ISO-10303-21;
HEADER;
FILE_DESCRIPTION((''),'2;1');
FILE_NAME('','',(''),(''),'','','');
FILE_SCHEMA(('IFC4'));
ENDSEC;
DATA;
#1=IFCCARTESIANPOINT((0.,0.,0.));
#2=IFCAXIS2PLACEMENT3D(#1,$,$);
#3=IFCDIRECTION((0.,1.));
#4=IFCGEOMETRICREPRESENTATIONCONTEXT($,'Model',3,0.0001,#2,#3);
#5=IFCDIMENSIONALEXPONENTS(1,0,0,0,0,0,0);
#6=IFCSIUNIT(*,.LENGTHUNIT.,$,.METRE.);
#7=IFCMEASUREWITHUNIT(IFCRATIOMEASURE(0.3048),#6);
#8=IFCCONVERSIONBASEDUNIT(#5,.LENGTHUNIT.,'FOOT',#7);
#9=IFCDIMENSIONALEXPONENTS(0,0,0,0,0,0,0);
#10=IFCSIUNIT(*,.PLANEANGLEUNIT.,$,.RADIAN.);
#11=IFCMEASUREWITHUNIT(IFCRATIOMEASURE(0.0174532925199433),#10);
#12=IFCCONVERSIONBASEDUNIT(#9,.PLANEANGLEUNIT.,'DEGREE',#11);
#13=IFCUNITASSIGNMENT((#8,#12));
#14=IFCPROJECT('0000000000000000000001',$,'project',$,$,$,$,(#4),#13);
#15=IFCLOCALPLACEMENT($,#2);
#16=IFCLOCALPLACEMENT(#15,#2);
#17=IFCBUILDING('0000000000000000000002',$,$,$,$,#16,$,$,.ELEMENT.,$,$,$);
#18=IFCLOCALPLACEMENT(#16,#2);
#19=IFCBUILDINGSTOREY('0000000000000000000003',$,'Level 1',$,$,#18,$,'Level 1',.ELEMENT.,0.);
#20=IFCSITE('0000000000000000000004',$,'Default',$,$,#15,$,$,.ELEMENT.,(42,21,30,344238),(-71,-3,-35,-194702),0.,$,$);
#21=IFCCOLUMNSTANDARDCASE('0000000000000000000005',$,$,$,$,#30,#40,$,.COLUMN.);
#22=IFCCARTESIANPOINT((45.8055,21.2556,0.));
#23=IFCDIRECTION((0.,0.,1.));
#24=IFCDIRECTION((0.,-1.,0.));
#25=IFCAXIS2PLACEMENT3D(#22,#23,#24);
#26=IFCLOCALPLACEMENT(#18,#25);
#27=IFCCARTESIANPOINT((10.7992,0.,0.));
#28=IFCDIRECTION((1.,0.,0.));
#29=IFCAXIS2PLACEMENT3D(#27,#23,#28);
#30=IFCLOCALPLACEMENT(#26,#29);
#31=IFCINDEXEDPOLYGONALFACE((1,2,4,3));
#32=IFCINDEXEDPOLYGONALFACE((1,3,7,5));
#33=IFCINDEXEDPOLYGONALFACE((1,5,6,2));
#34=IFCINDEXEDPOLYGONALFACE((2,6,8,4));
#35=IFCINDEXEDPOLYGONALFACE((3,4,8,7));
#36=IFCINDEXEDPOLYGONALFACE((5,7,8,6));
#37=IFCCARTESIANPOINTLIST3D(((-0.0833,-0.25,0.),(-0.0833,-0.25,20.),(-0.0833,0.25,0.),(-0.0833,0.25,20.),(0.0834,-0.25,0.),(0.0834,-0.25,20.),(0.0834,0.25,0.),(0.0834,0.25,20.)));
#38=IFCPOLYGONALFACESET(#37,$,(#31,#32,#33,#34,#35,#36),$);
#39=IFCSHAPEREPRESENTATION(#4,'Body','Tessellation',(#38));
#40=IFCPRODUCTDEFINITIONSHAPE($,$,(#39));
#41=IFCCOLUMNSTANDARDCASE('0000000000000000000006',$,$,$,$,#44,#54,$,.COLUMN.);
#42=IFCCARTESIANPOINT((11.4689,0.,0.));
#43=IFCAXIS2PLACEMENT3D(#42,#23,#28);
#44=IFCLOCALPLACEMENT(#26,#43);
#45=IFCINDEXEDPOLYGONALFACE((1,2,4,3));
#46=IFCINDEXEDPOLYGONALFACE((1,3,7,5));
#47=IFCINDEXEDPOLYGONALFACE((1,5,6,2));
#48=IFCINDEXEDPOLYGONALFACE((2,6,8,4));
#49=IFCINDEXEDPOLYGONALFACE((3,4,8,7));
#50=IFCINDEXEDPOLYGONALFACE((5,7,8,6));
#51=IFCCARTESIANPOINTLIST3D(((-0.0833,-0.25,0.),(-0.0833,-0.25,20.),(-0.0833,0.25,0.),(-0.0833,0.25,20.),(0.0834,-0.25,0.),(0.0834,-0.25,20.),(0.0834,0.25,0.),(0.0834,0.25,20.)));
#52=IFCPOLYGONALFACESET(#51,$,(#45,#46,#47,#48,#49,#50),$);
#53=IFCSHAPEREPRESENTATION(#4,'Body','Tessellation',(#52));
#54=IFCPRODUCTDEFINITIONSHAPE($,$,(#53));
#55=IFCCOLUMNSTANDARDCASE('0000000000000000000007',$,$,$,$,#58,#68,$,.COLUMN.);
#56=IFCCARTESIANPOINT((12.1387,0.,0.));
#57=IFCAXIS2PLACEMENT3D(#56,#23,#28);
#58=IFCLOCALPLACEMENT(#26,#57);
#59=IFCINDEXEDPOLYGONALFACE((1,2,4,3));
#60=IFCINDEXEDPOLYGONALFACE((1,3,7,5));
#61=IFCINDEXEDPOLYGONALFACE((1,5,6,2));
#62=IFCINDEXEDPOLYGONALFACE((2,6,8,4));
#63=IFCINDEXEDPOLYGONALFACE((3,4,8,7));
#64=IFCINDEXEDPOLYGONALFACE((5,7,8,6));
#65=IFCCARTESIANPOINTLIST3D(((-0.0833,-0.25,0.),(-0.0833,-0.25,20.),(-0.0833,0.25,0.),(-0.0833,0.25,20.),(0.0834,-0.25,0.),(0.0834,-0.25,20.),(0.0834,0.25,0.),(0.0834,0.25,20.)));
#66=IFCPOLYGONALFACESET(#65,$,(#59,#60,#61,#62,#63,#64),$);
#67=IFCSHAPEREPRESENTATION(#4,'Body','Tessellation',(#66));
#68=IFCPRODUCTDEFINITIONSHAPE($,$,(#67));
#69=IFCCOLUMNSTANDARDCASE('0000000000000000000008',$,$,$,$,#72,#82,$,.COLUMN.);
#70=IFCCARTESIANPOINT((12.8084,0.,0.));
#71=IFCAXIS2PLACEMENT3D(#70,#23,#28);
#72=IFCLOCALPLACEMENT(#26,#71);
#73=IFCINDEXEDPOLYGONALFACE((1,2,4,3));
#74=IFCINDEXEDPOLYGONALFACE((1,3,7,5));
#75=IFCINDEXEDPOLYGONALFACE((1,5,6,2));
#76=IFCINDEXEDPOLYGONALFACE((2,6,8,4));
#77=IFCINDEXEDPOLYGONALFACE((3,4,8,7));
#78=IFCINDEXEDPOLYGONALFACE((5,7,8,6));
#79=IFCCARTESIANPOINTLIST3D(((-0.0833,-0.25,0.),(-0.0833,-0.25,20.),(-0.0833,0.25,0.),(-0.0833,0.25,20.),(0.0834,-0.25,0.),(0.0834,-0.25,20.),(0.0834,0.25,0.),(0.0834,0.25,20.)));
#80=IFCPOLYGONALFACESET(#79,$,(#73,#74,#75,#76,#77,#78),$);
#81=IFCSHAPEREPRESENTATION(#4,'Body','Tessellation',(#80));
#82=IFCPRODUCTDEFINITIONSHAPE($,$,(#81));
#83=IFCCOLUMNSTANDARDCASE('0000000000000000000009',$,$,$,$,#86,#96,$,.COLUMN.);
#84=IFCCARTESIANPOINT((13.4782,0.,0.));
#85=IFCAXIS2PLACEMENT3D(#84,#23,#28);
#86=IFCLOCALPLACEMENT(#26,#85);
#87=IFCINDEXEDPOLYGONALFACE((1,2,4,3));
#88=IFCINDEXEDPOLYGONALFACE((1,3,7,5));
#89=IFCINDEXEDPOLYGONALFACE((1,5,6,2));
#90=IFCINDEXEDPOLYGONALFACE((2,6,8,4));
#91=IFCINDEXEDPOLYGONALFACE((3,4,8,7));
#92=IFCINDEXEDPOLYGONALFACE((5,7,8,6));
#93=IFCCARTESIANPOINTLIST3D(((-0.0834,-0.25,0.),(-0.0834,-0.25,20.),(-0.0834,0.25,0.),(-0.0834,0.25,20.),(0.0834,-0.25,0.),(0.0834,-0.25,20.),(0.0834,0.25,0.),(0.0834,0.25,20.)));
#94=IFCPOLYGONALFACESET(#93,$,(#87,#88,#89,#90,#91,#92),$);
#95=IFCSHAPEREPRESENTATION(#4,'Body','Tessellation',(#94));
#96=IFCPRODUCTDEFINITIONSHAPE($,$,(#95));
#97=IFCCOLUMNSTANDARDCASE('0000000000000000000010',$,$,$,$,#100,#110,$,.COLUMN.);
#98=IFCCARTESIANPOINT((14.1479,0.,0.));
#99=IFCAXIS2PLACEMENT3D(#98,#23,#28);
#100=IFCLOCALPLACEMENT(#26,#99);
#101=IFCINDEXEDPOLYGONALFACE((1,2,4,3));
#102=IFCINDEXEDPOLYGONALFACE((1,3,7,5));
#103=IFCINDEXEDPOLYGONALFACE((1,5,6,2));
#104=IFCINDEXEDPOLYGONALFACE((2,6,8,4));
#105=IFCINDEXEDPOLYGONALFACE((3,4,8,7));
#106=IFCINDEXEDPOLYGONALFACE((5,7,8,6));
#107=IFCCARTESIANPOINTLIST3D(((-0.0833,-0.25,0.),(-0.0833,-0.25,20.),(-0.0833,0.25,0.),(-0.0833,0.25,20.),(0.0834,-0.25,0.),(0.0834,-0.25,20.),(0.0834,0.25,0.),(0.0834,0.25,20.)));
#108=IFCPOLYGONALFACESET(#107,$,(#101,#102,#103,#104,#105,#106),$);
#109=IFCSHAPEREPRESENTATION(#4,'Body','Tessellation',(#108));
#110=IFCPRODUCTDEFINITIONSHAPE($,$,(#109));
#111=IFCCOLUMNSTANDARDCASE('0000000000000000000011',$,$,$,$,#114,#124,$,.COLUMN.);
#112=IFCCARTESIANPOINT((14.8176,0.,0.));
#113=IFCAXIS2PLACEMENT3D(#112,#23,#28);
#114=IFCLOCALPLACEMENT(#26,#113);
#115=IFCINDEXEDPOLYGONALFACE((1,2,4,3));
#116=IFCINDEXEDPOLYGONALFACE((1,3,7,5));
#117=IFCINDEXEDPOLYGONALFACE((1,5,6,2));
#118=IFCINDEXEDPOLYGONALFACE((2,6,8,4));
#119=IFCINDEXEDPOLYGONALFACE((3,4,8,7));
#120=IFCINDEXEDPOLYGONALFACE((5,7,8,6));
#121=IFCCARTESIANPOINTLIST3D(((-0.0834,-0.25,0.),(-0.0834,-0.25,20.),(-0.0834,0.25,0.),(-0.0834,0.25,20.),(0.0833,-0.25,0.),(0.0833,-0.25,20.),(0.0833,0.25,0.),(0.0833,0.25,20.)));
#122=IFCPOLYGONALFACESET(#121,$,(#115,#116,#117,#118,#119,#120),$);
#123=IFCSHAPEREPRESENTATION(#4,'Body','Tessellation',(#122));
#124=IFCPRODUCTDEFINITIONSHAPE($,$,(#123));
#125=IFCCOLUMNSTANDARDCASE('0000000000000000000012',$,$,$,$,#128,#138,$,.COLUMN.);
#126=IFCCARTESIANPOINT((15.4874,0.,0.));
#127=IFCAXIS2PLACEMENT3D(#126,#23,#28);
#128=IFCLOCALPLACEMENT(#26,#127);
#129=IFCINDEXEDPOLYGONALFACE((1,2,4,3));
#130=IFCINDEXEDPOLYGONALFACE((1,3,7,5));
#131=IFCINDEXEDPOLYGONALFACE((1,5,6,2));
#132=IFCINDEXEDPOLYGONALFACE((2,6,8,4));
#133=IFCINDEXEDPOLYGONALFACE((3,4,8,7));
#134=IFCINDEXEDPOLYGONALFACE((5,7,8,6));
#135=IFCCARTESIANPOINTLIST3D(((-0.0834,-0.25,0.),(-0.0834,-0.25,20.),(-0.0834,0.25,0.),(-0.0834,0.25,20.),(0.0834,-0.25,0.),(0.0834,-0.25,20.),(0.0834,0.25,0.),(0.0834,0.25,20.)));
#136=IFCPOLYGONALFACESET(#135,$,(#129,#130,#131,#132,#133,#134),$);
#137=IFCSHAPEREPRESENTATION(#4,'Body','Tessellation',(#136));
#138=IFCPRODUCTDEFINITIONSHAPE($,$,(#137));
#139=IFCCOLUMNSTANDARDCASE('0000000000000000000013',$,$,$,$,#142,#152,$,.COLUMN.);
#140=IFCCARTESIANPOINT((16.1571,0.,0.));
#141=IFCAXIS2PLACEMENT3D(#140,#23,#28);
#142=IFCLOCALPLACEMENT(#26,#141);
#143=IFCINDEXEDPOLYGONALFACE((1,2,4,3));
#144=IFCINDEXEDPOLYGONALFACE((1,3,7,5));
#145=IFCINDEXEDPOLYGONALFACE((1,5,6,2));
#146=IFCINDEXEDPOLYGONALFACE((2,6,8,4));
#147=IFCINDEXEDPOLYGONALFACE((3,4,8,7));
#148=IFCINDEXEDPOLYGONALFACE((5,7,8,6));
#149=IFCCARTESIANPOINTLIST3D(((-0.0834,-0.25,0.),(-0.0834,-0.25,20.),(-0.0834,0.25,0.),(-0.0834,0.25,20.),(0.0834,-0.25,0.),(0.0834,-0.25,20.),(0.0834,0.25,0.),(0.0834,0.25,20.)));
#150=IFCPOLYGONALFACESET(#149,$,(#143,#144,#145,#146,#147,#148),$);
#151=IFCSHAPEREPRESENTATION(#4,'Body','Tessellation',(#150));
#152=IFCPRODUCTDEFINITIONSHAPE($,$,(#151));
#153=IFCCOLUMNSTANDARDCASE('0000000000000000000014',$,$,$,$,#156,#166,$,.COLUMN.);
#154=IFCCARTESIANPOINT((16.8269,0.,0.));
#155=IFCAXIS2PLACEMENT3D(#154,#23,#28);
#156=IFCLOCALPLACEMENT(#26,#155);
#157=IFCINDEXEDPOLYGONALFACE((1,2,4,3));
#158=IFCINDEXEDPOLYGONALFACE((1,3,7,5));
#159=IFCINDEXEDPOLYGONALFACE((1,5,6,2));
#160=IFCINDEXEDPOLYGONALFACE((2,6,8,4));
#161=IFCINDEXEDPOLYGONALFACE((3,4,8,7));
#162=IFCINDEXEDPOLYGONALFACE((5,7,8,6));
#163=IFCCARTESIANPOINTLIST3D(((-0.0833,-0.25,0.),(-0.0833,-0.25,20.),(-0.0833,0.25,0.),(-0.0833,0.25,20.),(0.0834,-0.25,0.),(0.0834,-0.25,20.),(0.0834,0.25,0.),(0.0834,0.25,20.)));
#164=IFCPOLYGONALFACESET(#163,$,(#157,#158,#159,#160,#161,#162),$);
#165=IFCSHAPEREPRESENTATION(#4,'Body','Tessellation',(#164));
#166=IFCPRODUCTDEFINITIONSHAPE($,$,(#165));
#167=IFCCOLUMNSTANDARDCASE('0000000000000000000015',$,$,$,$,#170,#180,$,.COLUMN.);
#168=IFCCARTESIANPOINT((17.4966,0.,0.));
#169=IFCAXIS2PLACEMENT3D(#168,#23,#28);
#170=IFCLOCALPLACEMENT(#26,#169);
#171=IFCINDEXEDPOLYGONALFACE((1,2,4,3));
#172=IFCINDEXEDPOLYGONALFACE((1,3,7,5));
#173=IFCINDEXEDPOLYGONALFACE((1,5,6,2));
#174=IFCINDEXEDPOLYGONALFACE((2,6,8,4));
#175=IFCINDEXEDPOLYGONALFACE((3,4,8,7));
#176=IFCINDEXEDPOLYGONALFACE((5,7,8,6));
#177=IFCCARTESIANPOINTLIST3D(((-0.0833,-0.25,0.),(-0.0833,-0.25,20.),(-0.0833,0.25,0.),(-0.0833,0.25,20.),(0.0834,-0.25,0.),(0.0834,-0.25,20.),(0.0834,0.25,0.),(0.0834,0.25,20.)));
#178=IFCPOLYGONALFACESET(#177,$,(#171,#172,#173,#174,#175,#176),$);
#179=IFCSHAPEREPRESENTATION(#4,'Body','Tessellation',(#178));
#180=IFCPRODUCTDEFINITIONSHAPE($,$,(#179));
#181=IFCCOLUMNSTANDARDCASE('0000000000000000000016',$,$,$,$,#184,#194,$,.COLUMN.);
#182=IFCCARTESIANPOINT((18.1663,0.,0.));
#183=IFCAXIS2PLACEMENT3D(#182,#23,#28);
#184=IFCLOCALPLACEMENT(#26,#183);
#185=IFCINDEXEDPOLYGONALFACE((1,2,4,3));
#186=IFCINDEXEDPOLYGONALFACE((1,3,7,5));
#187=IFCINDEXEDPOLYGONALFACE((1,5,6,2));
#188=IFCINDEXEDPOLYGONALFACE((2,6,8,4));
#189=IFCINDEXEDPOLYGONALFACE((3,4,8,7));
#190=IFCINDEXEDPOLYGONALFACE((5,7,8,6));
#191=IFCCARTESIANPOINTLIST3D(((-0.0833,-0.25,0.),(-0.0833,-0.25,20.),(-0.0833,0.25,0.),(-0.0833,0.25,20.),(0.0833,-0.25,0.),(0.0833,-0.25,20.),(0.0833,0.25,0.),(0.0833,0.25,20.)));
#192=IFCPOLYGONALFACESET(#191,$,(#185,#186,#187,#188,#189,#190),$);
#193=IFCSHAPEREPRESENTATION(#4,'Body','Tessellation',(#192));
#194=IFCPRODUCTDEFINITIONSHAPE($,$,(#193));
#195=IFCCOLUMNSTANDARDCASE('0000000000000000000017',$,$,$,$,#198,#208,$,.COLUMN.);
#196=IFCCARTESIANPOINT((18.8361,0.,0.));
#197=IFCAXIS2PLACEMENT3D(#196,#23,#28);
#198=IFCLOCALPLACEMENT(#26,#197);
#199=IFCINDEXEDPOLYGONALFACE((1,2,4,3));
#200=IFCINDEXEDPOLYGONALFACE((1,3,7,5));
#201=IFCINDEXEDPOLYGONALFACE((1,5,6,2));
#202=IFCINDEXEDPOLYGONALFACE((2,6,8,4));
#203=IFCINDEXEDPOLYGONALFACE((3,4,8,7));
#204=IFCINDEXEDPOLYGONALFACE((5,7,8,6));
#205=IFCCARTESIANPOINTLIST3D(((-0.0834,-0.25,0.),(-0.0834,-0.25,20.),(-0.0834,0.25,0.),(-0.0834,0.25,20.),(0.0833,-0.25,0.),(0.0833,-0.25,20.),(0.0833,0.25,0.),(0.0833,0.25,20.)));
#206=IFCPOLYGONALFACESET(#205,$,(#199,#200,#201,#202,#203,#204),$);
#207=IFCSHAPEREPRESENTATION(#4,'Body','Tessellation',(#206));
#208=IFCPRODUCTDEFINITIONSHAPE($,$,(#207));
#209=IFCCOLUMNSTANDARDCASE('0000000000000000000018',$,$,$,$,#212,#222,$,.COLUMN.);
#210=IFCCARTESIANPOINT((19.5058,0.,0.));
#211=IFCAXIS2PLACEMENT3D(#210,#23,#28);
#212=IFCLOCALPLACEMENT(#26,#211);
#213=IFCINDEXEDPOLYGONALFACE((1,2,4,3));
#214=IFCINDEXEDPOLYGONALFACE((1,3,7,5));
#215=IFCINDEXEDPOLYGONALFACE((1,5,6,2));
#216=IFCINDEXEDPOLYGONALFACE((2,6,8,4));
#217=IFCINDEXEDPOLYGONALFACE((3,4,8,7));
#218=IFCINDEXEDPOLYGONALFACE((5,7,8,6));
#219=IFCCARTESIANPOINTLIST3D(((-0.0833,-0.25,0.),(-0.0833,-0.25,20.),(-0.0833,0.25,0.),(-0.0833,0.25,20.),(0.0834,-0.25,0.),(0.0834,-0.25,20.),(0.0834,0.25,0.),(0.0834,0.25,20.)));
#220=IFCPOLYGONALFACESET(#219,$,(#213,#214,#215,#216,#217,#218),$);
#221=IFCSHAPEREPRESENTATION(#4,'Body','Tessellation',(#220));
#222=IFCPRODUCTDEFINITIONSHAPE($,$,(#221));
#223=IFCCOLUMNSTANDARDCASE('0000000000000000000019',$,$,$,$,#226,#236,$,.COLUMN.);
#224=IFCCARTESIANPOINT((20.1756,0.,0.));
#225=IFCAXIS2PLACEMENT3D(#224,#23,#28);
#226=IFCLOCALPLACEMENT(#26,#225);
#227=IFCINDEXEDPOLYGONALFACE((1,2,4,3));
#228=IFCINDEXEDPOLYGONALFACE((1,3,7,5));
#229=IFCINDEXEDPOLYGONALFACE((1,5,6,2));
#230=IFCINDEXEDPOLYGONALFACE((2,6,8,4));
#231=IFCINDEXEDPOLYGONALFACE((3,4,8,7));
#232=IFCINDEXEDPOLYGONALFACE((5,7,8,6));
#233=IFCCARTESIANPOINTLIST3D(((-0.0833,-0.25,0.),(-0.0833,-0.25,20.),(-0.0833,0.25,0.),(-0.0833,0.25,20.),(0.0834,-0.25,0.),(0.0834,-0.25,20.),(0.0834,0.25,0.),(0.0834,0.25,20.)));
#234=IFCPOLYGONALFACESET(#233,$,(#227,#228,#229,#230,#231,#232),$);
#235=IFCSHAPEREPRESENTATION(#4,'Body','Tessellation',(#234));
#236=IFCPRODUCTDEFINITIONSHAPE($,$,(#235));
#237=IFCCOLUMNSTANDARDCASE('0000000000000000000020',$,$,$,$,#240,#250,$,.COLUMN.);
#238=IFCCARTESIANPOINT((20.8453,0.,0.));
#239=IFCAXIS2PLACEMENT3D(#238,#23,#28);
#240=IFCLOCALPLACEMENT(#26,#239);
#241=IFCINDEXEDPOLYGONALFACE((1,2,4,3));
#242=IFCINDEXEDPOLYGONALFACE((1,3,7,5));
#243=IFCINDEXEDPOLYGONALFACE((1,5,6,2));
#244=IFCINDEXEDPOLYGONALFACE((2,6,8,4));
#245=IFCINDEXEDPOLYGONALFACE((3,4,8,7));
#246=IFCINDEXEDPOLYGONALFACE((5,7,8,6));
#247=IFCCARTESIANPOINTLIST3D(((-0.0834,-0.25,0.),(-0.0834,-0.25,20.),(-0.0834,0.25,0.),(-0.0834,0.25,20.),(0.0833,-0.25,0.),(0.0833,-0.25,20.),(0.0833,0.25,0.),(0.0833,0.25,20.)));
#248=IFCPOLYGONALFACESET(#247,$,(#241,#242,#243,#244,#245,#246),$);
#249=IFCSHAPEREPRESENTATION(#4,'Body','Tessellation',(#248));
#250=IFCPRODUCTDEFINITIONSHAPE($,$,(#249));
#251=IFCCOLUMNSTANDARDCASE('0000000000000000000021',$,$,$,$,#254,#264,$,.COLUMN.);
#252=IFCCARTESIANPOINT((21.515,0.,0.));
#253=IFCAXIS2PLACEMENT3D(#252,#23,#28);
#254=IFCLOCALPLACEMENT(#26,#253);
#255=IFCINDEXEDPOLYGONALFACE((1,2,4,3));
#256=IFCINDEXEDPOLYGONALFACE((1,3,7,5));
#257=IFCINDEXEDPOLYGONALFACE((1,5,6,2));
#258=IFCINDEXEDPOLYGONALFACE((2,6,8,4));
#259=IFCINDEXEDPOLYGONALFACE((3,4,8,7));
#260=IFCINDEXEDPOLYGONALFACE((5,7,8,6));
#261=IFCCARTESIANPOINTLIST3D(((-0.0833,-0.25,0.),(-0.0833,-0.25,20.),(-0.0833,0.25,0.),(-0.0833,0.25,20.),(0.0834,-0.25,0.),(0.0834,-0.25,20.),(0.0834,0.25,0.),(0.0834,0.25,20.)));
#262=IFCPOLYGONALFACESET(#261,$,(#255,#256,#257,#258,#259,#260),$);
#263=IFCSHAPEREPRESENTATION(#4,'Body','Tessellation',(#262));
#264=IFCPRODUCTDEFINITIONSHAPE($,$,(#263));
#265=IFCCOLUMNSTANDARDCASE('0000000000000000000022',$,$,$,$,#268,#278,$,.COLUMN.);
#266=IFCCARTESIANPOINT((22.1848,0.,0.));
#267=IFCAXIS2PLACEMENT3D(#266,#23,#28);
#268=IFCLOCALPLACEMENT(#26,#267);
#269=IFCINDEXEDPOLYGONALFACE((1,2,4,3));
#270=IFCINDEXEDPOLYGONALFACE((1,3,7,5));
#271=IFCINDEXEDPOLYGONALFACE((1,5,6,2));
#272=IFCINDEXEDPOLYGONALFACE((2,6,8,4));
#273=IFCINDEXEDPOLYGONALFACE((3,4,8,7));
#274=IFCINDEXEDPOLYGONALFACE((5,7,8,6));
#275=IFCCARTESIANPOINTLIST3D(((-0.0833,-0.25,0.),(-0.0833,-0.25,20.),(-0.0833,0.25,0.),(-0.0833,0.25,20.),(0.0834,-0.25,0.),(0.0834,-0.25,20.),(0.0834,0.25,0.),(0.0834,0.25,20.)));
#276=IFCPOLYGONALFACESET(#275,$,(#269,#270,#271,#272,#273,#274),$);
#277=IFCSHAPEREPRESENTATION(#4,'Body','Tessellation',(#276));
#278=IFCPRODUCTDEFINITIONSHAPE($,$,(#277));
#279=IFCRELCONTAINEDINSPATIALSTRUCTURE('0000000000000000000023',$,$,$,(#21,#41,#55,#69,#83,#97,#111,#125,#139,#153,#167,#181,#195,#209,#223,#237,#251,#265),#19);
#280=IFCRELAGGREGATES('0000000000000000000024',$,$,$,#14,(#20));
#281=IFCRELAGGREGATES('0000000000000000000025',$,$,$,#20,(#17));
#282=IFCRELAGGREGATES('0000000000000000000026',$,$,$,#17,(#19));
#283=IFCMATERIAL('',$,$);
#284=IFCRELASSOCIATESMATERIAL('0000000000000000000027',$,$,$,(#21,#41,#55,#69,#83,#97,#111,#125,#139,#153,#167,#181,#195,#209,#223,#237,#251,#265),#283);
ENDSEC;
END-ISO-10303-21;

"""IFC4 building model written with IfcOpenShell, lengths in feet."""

from ifc_helpers import new_model, entity, si_unit, converted_unit, direction, frame, origin, place, context, project, spatial, rectangle, extrude, material, element, save


model = new_model("IFC4")

# Units and contexts
model_context = context("Model", 3, precision=0.0001, world=origin(), true_north=direction((0.0, 1.0)))
ifc_project = project(units=[converted_unit("LENGTHUNIT", "FOOT", entity("IfcRatioMeasure", 0.3048), si_unit("LENGTHUNIT", "METRE"), dimensions=[1, 0, 0, 0, 0, 0, 0]), converted_unit("PLANEANGLEUNIT", "DEGREE", entity("IfcRatioMeasure", 0.0174532925199433), si_unit("PLANEANGLEUNIT", "RADIAN"), dimensions=[0, 0, 0, 0, 0, 0, 0])], contexts=[model_context])

# Site, building, storey
site_placement = place(None, origin())
site = spatial("IfcSite", under=ifc_project, at=site_placement, Name="Default", CompositionType="ELEMENT", RefLatitude=(42, 21, 30, 344238), RefLongitude=(-71, -3, -35, -194702), RefElevation=0.0)
building_placement = place(site_placement, origin())
building = spatial("IfcBuilding", under=site, at=building_placement, CompositionType="ELEMENT")
storey_placement = place(building_placement, origin())
storey = spatial("IfcBuildingStorey", under=building, at=storey_placement, Name="Level 1", LongName="Level 1", CompositionType="ELEMENT", Elevation=0.0)

# Columns
ifc_material = material(Name="")
placement = place(storey_placement, frame((45.8055, 21.2556, 0.0), z_axis=(0.0, 0.0, 1.0), x_axis=(0.0, -1.0, 0.0)))
for number, where, z_axis, x_axis in (
    (1, (10.7992, 0.0, 0.0), (0.0, 0.0, 1.0), (1.0, 0.0, 0.0)),
    (2, (11.4689, 0.0, 0.0), (0.0, 0.0, 1.0), (1.0, 0.0, 0.0)),
    (3, (12.1387, 0.0, 0.0), (0.0, 0.0, 1.0), (1.0, 0.0, 0.0)),
    (4, (12.8084, 0.0, 0.0), (0.0, 0.0, 1.0), (1.0, 0.0, 0.0)),
    (5, (13.4782, 0.0, 0.0), (0.0, 0.0, 1.0), (1.0, 0.0, 0.0)),
    (6, (14.1479, 0.0, 0.0), (0.0, 0.0, 1.0), (1.0, 0.0, 0.0)),
    (7, (14.8176, 0.0, 0.0), (0.0, 0.0, 1.0), (1.0, 0.0, 0.0)),
    (8, (15.4874, 0.0, 0.0), (0.0, 0.0, 1.0), (1.0, 0.0, 0.0)),
    (9, (16.1571, 0.0, 0.0), (0.0, 0.0, 1.0), (1.0, 0.0, 0.0)),
    (10, (16.8269, 0.0, 0.0), (0.0, 0.0, 1.0), (1.0, 0.0, 0.0)),
    (11, (17.4966, 0.0, 0.0), (0.0, 0.0, 1.0), (1.0, 0.0, 0.0)),
    (12, (18.1663, 0.0, 0.0), (0.0, 0.0, 1.0), (1.0, 0.0, 0.0)),
    (13, (18.8361, 0.0, 0.0), (0.0, 0.0, 1.0), (1.0, 0.0, 0.0)),
    (14, (19.5058, 0.0, 0.0), (0.0, 0.0, 1.0), (1.0, 0.0, 0.0)),
    (15, (20.1756, 0.0, 0.0), (0.0, 0.0, 1.0), (1.0, 0.0, 0.0)),
    (16, (20.8453, 0.0, 0.0), (0.0, 0.0, 1.0), (1.0, 0.0, 0.0)),
    (17, (21.515, 0.0, 0.0), (0.0, 0.0, 1.0), (1.0, 0.0, 0.0)),
    (18, (22.1848, 0.0, 0.0), (0.0, 0.0, 1.0), (1.0, 0.0, 0.0)),
):
    element("IfcColumnStandardCase", number, at=place(placement, frame(where, z_axis=z_axis, x_axis=x_axis)), inside=storey, material=ifc_material, PredefinedType="COLUMN", context=model_context, shape_type="SweptSolid", body=[
        extrude(rectangle(XDim=0.1667, YDim=0.5), origin(), (0.0, 0.0, 1.0), 20.0),
    ])

save(model, "model.ifc")
